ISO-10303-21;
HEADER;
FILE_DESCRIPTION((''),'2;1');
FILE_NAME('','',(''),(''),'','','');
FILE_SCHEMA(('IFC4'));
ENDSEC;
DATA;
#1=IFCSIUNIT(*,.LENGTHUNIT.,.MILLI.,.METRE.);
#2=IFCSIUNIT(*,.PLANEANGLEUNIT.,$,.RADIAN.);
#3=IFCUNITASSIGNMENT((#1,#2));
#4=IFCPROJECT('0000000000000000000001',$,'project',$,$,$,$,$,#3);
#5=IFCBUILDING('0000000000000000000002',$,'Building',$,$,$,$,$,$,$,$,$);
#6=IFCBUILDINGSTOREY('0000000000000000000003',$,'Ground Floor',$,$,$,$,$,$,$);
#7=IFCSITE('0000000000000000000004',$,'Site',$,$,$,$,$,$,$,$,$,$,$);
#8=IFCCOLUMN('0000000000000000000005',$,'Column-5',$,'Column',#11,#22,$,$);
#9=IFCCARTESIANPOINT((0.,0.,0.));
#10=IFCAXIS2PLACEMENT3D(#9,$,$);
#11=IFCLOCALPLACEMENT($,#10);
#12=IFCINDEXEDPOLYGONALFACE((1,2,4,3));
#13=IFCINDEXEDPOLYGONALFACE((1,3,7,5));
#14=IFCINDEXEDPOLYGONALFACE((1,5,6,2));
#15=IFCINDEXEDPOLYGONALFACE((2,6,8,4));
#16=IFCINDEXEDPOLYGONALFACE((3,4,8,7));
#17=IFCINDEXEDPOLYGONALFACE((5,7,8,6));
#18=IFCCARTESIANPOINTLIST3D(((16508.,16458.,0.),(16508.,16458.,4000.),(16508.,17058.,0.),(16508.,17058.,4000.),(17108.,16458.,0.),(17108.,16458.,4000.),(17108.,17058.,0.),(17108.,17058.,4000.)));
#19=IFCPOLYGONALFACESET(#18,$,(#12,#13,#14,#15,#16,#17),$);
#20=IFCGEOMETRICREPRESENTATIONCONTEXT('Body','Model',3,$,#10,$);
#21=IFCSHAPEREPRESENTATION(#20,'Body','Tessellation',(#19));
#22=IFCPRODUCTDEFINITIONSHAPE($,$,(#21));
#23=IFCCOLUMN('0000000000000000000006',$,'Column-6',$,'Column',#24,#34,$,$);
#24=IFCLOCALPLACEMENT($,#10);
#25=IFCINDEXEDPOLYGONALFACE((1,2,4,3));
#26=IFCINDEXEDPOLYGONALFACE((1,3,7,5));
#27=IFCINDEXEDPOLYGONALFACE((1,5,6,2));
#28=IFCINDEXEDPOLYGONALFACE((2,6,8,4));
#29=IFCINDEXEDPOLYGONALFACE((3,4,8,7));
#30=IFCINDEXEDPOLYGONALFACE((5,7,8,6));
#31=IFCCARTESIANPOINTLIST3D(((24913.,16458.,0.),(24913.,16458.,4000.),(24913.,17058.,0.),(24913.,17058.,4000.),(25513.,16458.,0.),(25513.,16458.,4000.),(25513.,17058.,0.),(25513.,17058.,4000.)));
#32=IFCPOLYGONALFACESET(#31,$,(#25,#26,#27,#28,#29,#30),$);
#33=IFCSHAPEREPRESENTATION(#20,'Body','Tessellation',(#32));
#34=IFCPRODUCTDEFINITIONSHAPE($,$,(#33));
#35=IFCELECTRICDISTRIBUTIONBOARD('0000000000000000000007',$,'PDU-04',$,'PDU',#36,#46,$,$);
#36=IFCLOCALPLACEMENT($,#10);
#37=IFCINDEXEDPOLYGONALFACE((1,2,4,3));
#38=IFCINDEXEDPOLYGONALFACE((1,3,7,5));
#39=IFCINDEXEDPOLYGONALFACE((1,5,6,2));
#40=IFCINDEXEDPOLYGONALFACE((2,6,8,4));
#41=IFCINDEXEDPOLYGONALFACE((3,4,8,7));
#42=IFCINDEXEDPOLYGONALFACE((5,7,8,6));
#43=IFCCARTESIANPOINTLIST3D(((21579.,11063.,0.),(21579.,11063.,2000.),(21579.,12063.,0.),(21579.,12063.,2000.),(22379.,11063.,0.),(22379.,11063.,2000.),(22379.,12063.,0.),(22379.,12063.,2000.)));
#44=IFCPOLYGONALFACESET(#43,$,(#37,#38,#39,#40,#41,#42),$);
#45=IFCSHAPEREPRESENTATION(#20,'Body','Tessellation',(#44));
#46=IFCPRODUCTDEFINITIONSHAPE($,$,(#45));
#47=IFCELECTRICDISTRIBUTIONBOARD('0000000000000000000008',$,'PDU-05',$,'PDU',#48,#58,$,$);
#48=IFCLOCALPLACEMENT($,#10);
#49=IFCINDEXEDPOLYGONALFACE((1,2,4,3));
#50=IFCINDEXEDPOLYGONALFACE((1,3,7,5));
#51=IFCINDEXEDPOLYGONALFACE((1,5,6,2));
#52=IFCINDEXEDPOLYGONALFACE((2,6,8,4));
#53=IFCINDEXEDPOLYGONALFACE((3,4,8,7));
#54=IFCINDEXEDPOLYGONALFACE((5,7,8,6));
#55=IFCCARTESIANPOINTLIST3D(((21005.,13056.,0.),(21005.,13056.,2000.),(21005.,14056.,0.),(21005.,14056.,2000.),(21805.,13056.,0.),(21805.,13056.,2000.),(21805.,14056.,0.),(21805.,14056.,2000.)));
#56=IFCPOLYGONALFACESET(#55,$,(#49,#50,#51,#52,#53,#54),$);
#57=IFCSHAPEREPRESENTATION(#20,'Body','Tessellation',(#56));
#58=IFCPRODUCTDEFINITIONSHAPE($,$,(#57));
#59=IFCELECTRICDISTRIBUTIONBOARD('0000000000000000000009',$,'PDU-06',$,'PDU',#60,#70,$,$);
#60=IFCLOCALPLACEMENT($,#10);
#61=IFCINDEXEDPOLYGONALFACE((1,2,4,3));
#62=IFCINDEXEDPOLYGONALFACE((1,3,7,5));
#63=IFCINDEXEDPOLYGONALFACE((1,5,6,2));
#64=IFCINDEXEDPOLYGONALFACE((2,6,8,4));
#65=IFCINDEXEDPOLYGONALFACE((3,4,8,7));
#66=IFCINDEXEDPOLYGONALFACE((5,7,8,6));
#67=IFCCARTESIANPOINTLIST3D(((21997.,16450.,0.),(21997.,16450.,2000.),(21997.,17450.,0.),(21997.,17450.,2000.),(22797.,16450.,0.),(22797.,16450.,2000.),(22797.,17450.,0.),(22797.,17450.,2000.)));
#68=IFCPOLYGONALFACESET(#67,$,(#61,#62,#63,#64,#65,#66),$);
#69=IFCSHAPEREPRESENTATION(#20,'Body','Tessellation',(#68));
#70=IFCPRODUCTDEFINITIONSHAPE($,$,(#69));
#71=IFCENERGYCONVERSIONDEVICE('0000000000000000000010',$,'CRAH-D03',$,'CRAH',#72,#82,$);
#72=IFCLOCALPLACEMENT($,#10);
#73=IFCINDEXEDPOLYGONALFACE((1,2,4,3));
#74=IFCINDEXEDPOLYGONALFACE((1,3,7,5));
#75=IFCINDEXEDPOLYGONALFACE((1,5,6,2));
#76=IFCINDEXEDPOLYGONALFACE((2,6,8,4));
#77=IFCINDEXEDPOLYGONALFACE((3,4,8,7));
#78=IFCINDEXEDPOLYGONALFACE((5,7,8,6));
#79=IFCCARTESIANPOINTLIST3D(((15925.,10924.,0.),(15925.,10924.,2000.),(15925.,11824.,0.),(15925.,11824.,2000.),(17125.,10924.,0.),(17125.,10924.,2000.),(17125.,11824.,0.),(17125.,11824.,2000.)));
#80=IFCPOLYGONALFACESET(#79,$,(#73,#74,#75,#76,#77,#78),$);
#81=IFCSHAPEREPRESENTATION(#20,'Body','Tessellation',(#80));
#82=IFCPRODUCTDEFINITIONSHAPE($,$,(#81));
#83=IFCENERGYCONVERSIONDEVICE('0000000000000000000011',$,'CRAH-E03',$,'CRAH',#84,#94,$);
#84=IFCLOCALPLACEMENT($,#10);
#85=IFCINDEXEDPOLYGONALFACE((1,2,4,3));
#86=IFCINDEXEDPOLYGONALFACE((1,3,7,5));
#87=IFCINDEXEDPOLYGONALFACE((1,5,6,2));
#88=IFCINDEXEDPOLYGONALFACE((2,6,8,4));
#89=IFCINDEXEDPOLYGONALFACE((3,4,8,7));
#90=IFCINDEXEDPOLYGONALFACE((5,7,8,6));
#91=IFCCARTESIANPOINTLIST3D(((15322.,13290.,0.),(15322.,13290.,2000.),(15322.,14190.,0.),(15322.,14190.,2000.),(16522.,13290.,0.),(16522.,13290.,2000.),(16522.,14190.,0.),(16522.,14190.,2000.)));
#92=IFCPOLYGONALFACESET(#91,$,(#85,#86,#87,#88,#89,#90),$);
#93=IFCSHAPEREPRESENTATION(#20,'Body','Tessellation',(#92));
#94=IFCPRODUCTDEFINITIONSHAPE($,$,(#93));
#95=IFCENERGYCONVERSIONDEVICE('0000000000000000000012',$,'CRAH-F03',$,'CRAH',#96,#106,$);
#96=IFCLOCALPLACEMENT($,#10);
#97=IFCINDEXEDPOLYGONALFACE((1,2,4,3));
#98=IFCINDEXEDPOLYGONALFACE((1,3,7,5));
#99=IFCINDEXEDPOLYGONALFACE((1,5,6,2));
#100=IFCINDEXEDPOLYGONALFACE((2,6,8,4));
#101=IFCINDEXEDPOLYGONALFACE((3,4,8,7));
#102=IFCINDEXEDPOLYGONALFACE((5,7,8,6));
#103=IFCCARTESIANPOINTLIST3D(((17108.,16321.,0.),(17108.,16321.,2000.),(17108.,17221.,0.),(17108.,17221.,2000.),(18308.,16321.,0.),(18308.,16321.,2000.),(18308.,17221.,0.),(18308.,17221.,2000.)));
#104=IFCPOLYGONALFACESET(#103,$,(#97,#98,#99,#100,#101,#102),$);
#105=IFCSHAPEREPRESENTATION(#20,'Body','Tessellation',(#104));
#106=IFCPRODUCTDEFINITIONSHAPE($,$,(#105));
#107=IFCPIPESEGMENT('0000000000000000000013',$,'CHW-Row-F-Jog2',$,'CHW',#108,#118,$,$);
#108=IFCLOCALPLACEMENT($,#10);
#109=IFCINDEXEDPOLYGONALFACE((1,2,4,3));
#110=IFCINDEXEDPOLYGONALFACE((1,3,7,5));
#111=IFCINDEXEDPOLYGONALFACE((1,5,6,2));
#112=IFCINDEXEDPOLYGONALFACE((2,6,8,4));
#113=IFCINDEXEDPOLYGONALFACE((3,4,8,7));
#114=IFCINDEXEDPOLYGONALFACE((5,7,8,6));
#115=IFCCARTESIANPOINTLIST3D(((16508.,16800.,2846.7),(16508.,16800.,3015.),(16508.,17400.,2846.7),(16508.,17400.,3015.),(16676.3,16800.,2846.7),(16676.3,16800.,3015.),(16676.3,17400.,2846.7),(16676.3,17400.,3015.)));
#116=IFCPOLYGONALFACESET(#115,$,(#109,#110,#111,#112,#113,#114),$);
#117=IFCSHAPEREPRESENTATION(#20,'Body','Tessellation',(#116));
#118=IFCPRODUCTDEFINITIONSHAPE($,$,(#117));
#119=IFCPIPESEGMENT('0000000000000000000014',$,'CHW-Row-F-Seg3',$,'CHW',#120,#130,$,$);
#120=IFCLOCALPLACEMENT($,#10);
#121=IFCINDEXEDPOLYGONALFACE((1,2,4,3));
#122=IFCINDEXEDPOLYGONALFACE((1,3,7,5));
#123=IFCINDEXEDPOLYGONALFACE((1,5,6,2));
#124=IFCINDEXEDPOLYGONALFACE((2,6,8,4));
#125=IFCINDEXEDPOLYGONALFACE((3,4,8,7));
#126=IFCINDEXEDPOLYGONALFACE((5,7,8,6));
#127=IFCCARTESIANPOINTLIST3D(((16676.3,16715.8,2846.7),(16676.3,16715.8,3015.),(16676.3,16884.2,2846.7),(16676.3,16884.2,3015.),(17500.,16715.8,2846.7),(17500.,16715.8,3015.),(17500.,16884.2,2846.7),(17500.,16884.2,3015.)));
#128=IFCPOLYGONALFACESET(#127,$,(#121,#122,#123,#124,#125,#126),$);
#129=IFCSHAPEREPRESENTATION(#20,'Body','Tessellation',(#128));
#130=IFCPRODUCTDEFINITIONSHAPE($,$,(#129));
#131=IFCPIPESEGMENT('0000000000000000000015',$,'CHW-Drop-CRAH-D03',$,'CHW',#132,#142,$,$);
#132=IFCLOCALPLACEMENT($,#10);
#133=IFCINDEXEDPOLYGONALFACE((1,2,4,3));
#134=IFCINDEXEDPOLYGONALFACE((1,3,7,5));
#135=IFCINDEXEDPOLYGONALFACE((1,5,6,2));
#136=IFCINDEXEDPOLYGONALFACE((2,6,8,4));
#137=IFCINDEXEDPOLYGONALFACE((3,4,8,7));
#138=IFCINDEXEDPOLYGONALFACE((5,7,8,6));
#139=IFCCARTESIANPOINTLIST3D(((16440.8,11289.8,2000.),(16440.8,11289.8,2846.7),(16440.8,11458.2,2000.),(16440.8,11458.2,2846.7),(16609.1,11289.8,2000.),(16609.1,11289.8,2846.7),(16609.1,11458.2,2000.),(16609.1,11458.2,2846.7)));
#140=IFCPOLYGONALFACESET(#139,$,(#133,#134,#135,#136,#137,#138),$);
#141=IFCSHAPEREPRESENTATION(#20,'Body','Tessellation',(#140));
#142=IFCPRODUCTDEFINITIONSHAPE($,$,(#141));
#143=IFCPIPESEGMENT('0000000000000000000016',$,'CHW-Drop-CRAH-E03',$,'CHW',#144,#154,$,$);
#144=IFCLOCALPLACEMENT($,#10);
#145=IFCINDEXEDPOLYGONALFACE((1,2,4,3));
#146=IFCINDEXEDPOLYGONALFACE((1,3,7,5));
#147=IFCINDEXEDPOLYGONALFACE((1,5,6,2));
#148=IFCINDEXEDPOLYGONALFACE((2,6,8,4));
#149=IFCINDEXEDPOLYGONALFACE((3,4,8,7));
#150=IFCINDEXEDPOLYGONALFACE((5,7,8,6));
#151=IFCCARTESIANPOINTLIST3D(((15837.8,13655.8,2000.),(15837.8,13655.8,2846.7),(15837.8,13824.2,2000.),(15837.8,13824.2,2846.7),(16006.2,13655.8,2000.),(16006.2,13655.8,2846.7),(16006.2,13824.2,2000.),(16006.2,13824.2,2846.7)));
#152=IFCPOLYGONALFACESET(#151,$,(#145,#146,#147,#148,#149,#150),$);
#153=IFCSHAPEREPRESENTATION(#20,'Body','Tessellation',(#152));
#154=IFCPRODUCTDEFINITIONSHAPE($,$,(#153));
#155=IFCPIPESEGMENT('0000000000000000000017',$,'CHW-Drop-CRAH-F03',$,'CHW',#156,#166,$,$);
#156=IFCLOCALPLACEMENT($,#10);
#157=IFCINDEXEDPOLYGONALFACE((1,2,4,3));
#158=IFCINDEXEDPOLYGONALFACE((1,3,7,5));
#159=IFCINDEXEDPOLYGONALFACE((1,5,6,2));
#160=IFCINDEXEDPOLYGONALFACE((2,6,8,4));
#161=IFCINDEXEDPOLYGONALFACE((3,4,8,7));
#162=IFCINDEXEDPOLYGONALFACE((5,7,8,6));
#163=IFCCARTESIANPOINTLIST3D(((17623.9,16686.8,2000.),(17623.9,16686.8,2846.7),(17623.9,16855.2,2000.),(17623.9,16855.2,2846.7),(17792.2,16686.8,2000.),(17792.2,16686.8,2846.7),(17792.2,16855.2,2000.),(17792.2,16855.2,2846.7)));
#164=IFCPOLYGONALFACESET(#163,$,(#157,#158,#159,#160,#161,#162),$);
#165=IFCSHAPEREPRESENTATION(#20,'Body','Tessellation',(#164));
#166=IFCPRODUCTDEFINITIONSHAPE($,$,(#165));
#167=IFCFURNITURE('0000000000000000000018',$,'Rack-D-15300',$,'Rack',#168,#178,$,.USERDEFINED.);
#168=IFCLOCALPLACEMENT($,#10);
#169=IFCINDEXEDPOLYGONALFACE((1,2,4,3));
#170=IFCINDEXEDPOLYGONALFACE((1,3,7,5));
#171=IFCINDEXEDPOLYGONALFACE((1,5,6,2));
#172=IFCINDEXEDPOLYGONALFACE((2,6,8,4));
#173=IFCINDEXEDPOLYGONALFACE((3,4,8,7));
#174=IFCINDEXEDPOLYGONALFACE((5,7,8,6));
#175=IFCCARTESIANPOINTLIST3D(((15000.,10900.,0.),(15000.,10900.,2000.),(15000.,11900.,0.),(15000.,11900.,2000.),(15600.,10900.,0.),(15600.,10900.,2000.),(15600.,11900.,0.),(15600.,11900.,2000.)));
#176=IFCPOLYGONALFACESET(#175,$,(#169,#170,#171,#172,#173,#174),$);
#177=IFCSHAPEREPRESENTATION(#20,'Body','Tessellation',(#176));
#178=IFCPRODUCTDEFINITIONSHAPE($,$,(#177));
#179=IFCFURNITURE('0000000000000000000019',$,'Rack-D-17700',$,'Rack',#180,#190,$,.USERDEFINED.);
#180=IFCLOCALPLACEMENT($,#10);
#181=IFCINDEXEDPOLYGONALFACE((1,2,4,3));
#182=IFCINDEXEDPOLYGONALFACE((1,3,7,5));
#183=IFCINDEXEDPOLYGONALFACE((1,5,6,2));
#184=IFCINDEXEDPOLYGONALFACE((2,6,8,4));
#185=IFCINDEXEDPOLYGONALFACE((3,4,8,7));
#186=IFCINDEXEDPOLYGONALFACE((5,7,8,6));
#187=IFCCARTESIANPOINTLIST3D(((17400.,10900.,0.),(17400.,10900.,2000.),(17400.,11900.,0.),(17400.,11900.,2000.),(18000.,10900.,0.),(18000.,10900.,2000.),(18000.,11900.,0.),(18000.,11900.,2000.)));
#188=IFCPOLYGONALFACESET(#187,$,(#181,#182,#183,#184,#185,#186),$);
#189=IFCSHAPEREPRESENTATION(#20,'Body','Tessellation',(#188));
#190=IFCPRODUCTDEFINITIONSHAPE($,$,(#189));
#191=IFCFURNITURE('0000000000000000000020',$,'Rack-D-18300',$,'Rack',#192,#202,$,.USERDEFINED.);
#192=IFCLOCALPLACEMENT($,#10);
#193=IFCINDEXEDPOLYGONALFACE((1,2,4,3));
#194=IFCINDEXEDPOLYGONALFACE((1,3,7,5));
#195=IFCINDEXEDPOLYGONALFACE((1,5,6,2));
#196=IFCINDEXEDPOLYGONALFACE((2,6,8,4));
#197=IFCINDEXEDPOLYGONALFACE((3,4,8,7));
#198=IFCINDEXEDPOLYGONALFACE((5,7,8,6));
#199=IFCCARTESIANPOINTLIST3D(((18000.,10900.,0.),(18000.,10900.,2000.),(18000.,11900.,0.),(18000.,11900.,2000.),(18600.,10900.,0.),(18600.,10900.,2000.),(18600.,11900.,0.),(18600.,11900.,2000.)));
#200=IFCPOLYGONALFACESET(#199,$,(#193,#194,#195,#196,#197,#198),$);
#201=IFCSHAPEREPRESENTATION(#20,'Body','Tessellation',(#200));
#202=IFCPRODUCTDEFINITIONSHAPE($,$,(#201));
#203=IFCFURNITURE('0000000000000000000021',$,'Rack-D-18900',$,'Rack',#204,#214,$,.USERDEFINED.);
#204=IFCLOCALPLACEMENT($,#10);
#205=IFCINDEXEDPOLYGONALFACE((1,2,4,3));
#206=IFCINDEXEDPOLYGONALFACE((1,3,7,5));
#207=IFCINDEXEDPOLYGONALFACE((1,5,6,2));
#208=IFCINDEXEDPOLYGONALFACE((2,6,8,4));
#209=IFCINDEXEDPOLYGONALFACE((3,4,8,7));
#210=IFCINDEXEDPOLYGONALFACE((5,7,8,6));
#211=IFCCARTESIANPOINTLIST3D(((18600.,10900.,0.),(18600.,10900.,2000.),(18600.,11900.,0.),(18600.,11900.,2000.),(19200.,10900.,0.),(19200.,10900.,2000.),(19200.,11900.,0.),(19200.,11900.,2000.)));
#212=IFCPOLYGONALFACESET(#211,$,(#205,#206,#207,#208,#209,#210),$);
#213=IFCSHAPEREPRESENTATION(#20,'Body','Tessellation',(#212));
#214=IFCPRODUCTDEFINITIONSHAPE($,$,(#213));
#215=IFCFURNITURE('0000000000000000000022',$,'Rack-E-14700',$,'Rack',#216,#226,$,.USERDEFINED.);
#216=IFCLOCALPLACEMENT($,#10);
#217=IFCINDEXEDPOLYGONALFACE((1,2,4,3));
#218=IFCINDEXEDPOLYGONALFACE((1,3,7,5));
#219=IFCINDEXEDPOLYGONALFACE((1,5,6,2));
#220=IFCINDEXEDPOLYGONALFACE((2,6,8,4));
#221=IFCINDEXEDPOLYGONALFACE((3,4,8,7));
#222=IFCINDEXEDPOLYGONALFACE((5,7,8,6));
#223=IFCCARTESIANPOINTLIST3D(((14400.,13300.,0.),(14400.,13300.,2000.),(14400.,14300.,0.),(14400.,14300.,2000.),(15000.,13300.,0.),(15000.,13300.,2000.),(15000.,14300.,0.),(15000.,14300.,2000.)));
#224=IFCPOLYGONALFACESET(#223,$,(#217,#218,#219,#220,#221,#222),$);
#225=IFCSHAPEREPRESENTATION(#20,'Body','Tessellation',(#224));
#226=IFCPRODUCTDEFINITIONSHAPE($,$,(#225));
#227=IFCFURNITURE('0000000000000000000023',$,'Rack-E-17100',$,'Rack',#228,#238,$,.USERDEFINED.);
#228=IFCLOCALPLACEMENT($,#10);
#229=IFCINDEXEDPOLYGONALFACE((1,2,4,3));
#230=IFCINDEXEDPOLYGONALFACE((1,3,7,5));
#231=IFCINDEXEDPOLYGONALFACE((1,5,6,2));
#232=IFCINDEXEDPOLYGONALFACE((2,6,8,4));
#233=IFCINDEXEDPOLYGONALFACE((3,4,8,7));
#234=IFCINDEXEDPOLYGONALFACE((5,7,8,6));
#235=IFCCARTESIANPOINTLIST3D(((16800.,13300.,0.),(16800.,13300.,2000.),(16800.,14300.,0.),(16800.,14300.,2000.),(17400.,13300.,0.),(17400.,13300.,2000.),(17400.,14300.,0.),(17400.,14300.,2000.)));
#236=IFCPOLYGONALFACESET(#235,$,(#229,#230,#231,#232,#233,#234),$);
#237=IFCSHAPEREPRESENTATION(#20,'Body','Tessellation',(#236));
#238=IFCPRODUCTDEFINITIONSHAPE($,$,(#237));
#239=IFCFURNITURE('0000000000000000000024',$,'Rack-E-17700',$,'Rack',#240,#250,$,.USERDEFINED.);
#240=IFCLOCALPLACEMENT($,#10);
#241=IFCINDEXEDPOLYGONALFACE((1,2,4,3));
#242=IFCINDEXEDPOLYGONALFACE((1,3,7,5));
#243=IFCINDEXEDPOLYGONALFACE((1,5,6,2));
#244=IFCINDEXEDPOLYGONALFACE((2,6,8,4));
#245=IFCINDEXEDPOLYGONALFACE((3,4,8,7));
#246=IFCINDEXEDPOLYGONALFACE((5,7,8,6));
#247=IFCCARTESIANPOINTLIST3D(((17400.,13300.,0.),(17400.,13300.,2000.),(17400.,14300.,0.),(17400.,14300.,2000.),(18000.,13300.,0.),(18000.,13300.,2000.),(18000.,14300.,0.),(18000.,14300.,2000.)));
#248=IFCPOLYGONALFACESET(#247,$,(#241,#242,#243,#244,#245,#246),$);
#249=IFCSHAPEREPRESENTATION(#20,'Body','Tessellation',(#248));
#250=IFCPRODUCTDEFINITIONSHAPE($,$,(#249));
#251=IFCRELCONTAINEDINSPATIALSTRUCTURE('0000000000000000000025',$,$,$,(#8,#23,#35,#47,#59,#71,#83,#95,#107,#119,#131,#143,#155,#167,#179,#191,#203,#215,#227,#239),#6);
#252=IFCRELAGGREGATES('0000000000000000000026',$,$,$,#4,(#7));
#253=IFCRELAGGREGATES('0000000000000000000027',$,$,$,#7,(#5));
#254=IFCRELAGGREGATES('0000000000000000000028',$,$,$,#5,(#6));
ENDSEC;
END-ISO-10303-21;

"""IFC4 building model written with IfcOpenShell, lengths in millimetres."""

from ifc_helpers import new_model, si_unit, frame, origin, place, context, project, spatial, rectangle, extrude, element, save


model = new_model("IFC4")

# Units and contexts
model_context = context("Model", 3, world=origin(), identifier="Body")
ifc_project = project(units=[si_unit("LENGTHUNIT", "METRE", prefix="MILLI"), si_unit("PLANEANGLEUNIT", "RADIAN")])

# Site, building, storey
site = spatial("IfcSite", under=ifc_project, Name="Site")
building = spatial("IfcBuilding", under=site, Name="Building")
storey = spatial("IfcBuildingStorey", under=building, Name="Ground Floor")

# Columns
for number, where, z_axis, x_axis, name in (
    (1, (16808.0, 16758.0, 0.0), (0.0, 0.0, 1.0), (1.0, 0.0, 0.0), "Column-5"),
    (2, (25213.0, 16758.0, 0.0), (0.0, 0.0, 1.0), (1.0, 0.0, 0.0), "Column-6"),
):
    element("IfcColumn", number, at=place(None, frame(where, z_axis=z_axis, x_axis=x_axis)), inside=storey, Name=name, ObjectType="Column", context=model_context, shape_type="SweptSolid", body=[
        extrude(rectangle(XDim=600.0, YDim=600.0), origin(), (0.0, 0.0, 1.0), 4000.0),
    ])

# Electric distribution boards
for number, where, z_axis, x_axis, name in (
    (3, (21979.0, 11563.0, 0.0), (0.0, 0.0, 1.0), (1.0, 0.0, 0.0), "PDU-04"),
    (4, (21405.0, 13556.0, 0.0), (0.0, 0.0, 1.0), (1.0, 0.0, 0.0), "PDU-05"),
    (5, (22397.0, 16950.0, 0.0), (0.0, 0.0, 1.0), (1.0, 0.0, 0.0), "PDU-06"),
):
    element("IfcElectricDistributionBoard", number, at=place(None, frame(where, z_axis=z_axis, x_axis=x_axis)), inside=storey, Name=name, ObjectType="PDU", context=model_context, shape_type="SweptSolid", body=[
        extrude(rectangle(XDim=800.0, YDim=1000.0), origin(), (0.0, 0.0, 1.0), 2000.0),
    ])

# Energy conversion devices
for number, where, z_axis, x_axis, name in (
    (6, (16525.0, 11374.0, 0.0), (0.0, 0.0, 1.0), (1.0, 0.0, 0.0), "CRAH-D03"),
    (7, (15922.0, 13740.0, 0.0), (0.0, 0.0, 1.0), (1.0, 0.0, 0.0), "CRAH-E03"),
    (8, (17708.0, 16771.0, 0.0), (0.0, 0.0, 1.0), (1.0, 0.0, 0.0), "CRAH-F03"),
):
    element("IfcEnergyConversionDevice", number, at=place(None, frame(where, z_axis=z_axis, x_axis=x_axis)), inside=storey, Name=name, ObjectType="CRAH", context=model_context, shape_type="SweptSolid", body=[
        extrude(rectangle(XDim=1200.0, YDim=900.0), origin(), (0.0, 0.0, 1.0), 2000.0),
    ])

# Pipe segments
pipe_segment_1_placement = place(None, frame((16592.2, 17100.0, 2846.7), z_axis=(0.0, 0.0, 1.0), x_axis=(1.0, 0.0, 0.0)))
element("IfcPipeSegment", 9, at=pipe_segment_1_placement, inside=storey, Name="CHW-Row-F-Jog2", ObjectType="CHW", context=model_context, shape_type="SweptSolid", body=[
    extrude(rectangle(XDim=168.3, YDim=600.0), origin(), (0.0, 0.0, 1.0), 168.3),
])
pipe_segment_2_placement = place(None, frame((17088.2, 16800.0, 2846.7), z_axis=(0.0, 0.0, 1.0), x_axis=(1.0, 0.0, 0.0)))
element("IfcPipeSegment", 10, at=pipe_segment_2_placement, inside=storey, Name="CHW-Row-F-Seg3", ObjectType="CHW", context=model_context, shape_type="SweptSolid", body=[
    extrude(rectangle(XDim=823.7, YDim=168.3), origin(), (0.0, 0.0, 1.0), 168.3),
])
for number, where, z_axis, x_axis, name in (
    (11, (16525.0, 11374.0, 2000.0), (0.0, 0.0, 1.0), (1.0, 0.0, 0.0), "CHW-Drop-CRAH-D03"),
    (12, (15922.0, 13740.0, 2000.0), (0.0, 0.0, 1.0), (1.0, 0.0, 0.0), "CHW-Drop-CRAH-E03"),
    (13, (17708.0, 16771.0, 2000.0), (0.0, 0.0, 1.0), (1.0, 0.0, 0.0), "CHW-Drop-CRAH-F03"),
):
    element("IfcPipeSegment", number, at=place(None, frame(where, z_axis=z_axis, x_axis=x_axis)), inside=storey, Name=name, ObjectType="CHW", context=model_context, shape_type="SweptSolid", body=[
        extrude(rectangle(XDim=168.3, YDim=168.3), origin(), (0.0, 0.0, 1.0), 846.7),
    ])

# Furniture
for number, where, z_axis, x_axis, name in (
    (14, (15300.0, 11400.0, 0.0), (0.0, 0.0, 1.0), (1.0, 0.0, 0.0), "Rack-D-15300"),
    (15, (17700.0, 11400.0, 0.0), (0.0, 0.0, 1.0), (1.0, 0.0, 0.0), "Rack-D-17700"),
    (16, (18300.0, 11400.0, 0.0), (0.0, 0.0, 1.0), (1.0, 0.0, 0.0), "Rack-D-18300"),
    (17, (18900.0, 11400.0, 0.0), (0.0, 0.0, 1.0), (1.0, 0.0, 0.0), "Rack-D-18900"),
    (18, (14700.0, 13800.0, 0.0), (0.0, 0.0, 1.0), (1.0, 0.0, 0.0), "Rack-E-14700"),
    (19, (17100.0, 13800.0, 0.0), (0.0, 0.0, 1.0), (1.0, 0.0, 0.0), "Rack-E-17100"),
    (20, (17700.0, 13800.0, 0.0), (0.0, 0.0, 1.0), (1.0, 0.0, 0.0), "Rack-E-17700"),
):
    element("IfcFurniture", number, at=place(None, frame(where, z_axis=z_axis, x_axis=x_axis)), inside=storey, Name=name, ObjectType="Rack", PredefinedType="USERDEFINED", context=model_context, shape_type="SweptSolid", body=[
        extrude(rectangle(XDim=600.0, YDim=1000.0), origin(), (0.0, 0.0, 1.0), 2000.0),
    ])

save(model, "model.ifc")
